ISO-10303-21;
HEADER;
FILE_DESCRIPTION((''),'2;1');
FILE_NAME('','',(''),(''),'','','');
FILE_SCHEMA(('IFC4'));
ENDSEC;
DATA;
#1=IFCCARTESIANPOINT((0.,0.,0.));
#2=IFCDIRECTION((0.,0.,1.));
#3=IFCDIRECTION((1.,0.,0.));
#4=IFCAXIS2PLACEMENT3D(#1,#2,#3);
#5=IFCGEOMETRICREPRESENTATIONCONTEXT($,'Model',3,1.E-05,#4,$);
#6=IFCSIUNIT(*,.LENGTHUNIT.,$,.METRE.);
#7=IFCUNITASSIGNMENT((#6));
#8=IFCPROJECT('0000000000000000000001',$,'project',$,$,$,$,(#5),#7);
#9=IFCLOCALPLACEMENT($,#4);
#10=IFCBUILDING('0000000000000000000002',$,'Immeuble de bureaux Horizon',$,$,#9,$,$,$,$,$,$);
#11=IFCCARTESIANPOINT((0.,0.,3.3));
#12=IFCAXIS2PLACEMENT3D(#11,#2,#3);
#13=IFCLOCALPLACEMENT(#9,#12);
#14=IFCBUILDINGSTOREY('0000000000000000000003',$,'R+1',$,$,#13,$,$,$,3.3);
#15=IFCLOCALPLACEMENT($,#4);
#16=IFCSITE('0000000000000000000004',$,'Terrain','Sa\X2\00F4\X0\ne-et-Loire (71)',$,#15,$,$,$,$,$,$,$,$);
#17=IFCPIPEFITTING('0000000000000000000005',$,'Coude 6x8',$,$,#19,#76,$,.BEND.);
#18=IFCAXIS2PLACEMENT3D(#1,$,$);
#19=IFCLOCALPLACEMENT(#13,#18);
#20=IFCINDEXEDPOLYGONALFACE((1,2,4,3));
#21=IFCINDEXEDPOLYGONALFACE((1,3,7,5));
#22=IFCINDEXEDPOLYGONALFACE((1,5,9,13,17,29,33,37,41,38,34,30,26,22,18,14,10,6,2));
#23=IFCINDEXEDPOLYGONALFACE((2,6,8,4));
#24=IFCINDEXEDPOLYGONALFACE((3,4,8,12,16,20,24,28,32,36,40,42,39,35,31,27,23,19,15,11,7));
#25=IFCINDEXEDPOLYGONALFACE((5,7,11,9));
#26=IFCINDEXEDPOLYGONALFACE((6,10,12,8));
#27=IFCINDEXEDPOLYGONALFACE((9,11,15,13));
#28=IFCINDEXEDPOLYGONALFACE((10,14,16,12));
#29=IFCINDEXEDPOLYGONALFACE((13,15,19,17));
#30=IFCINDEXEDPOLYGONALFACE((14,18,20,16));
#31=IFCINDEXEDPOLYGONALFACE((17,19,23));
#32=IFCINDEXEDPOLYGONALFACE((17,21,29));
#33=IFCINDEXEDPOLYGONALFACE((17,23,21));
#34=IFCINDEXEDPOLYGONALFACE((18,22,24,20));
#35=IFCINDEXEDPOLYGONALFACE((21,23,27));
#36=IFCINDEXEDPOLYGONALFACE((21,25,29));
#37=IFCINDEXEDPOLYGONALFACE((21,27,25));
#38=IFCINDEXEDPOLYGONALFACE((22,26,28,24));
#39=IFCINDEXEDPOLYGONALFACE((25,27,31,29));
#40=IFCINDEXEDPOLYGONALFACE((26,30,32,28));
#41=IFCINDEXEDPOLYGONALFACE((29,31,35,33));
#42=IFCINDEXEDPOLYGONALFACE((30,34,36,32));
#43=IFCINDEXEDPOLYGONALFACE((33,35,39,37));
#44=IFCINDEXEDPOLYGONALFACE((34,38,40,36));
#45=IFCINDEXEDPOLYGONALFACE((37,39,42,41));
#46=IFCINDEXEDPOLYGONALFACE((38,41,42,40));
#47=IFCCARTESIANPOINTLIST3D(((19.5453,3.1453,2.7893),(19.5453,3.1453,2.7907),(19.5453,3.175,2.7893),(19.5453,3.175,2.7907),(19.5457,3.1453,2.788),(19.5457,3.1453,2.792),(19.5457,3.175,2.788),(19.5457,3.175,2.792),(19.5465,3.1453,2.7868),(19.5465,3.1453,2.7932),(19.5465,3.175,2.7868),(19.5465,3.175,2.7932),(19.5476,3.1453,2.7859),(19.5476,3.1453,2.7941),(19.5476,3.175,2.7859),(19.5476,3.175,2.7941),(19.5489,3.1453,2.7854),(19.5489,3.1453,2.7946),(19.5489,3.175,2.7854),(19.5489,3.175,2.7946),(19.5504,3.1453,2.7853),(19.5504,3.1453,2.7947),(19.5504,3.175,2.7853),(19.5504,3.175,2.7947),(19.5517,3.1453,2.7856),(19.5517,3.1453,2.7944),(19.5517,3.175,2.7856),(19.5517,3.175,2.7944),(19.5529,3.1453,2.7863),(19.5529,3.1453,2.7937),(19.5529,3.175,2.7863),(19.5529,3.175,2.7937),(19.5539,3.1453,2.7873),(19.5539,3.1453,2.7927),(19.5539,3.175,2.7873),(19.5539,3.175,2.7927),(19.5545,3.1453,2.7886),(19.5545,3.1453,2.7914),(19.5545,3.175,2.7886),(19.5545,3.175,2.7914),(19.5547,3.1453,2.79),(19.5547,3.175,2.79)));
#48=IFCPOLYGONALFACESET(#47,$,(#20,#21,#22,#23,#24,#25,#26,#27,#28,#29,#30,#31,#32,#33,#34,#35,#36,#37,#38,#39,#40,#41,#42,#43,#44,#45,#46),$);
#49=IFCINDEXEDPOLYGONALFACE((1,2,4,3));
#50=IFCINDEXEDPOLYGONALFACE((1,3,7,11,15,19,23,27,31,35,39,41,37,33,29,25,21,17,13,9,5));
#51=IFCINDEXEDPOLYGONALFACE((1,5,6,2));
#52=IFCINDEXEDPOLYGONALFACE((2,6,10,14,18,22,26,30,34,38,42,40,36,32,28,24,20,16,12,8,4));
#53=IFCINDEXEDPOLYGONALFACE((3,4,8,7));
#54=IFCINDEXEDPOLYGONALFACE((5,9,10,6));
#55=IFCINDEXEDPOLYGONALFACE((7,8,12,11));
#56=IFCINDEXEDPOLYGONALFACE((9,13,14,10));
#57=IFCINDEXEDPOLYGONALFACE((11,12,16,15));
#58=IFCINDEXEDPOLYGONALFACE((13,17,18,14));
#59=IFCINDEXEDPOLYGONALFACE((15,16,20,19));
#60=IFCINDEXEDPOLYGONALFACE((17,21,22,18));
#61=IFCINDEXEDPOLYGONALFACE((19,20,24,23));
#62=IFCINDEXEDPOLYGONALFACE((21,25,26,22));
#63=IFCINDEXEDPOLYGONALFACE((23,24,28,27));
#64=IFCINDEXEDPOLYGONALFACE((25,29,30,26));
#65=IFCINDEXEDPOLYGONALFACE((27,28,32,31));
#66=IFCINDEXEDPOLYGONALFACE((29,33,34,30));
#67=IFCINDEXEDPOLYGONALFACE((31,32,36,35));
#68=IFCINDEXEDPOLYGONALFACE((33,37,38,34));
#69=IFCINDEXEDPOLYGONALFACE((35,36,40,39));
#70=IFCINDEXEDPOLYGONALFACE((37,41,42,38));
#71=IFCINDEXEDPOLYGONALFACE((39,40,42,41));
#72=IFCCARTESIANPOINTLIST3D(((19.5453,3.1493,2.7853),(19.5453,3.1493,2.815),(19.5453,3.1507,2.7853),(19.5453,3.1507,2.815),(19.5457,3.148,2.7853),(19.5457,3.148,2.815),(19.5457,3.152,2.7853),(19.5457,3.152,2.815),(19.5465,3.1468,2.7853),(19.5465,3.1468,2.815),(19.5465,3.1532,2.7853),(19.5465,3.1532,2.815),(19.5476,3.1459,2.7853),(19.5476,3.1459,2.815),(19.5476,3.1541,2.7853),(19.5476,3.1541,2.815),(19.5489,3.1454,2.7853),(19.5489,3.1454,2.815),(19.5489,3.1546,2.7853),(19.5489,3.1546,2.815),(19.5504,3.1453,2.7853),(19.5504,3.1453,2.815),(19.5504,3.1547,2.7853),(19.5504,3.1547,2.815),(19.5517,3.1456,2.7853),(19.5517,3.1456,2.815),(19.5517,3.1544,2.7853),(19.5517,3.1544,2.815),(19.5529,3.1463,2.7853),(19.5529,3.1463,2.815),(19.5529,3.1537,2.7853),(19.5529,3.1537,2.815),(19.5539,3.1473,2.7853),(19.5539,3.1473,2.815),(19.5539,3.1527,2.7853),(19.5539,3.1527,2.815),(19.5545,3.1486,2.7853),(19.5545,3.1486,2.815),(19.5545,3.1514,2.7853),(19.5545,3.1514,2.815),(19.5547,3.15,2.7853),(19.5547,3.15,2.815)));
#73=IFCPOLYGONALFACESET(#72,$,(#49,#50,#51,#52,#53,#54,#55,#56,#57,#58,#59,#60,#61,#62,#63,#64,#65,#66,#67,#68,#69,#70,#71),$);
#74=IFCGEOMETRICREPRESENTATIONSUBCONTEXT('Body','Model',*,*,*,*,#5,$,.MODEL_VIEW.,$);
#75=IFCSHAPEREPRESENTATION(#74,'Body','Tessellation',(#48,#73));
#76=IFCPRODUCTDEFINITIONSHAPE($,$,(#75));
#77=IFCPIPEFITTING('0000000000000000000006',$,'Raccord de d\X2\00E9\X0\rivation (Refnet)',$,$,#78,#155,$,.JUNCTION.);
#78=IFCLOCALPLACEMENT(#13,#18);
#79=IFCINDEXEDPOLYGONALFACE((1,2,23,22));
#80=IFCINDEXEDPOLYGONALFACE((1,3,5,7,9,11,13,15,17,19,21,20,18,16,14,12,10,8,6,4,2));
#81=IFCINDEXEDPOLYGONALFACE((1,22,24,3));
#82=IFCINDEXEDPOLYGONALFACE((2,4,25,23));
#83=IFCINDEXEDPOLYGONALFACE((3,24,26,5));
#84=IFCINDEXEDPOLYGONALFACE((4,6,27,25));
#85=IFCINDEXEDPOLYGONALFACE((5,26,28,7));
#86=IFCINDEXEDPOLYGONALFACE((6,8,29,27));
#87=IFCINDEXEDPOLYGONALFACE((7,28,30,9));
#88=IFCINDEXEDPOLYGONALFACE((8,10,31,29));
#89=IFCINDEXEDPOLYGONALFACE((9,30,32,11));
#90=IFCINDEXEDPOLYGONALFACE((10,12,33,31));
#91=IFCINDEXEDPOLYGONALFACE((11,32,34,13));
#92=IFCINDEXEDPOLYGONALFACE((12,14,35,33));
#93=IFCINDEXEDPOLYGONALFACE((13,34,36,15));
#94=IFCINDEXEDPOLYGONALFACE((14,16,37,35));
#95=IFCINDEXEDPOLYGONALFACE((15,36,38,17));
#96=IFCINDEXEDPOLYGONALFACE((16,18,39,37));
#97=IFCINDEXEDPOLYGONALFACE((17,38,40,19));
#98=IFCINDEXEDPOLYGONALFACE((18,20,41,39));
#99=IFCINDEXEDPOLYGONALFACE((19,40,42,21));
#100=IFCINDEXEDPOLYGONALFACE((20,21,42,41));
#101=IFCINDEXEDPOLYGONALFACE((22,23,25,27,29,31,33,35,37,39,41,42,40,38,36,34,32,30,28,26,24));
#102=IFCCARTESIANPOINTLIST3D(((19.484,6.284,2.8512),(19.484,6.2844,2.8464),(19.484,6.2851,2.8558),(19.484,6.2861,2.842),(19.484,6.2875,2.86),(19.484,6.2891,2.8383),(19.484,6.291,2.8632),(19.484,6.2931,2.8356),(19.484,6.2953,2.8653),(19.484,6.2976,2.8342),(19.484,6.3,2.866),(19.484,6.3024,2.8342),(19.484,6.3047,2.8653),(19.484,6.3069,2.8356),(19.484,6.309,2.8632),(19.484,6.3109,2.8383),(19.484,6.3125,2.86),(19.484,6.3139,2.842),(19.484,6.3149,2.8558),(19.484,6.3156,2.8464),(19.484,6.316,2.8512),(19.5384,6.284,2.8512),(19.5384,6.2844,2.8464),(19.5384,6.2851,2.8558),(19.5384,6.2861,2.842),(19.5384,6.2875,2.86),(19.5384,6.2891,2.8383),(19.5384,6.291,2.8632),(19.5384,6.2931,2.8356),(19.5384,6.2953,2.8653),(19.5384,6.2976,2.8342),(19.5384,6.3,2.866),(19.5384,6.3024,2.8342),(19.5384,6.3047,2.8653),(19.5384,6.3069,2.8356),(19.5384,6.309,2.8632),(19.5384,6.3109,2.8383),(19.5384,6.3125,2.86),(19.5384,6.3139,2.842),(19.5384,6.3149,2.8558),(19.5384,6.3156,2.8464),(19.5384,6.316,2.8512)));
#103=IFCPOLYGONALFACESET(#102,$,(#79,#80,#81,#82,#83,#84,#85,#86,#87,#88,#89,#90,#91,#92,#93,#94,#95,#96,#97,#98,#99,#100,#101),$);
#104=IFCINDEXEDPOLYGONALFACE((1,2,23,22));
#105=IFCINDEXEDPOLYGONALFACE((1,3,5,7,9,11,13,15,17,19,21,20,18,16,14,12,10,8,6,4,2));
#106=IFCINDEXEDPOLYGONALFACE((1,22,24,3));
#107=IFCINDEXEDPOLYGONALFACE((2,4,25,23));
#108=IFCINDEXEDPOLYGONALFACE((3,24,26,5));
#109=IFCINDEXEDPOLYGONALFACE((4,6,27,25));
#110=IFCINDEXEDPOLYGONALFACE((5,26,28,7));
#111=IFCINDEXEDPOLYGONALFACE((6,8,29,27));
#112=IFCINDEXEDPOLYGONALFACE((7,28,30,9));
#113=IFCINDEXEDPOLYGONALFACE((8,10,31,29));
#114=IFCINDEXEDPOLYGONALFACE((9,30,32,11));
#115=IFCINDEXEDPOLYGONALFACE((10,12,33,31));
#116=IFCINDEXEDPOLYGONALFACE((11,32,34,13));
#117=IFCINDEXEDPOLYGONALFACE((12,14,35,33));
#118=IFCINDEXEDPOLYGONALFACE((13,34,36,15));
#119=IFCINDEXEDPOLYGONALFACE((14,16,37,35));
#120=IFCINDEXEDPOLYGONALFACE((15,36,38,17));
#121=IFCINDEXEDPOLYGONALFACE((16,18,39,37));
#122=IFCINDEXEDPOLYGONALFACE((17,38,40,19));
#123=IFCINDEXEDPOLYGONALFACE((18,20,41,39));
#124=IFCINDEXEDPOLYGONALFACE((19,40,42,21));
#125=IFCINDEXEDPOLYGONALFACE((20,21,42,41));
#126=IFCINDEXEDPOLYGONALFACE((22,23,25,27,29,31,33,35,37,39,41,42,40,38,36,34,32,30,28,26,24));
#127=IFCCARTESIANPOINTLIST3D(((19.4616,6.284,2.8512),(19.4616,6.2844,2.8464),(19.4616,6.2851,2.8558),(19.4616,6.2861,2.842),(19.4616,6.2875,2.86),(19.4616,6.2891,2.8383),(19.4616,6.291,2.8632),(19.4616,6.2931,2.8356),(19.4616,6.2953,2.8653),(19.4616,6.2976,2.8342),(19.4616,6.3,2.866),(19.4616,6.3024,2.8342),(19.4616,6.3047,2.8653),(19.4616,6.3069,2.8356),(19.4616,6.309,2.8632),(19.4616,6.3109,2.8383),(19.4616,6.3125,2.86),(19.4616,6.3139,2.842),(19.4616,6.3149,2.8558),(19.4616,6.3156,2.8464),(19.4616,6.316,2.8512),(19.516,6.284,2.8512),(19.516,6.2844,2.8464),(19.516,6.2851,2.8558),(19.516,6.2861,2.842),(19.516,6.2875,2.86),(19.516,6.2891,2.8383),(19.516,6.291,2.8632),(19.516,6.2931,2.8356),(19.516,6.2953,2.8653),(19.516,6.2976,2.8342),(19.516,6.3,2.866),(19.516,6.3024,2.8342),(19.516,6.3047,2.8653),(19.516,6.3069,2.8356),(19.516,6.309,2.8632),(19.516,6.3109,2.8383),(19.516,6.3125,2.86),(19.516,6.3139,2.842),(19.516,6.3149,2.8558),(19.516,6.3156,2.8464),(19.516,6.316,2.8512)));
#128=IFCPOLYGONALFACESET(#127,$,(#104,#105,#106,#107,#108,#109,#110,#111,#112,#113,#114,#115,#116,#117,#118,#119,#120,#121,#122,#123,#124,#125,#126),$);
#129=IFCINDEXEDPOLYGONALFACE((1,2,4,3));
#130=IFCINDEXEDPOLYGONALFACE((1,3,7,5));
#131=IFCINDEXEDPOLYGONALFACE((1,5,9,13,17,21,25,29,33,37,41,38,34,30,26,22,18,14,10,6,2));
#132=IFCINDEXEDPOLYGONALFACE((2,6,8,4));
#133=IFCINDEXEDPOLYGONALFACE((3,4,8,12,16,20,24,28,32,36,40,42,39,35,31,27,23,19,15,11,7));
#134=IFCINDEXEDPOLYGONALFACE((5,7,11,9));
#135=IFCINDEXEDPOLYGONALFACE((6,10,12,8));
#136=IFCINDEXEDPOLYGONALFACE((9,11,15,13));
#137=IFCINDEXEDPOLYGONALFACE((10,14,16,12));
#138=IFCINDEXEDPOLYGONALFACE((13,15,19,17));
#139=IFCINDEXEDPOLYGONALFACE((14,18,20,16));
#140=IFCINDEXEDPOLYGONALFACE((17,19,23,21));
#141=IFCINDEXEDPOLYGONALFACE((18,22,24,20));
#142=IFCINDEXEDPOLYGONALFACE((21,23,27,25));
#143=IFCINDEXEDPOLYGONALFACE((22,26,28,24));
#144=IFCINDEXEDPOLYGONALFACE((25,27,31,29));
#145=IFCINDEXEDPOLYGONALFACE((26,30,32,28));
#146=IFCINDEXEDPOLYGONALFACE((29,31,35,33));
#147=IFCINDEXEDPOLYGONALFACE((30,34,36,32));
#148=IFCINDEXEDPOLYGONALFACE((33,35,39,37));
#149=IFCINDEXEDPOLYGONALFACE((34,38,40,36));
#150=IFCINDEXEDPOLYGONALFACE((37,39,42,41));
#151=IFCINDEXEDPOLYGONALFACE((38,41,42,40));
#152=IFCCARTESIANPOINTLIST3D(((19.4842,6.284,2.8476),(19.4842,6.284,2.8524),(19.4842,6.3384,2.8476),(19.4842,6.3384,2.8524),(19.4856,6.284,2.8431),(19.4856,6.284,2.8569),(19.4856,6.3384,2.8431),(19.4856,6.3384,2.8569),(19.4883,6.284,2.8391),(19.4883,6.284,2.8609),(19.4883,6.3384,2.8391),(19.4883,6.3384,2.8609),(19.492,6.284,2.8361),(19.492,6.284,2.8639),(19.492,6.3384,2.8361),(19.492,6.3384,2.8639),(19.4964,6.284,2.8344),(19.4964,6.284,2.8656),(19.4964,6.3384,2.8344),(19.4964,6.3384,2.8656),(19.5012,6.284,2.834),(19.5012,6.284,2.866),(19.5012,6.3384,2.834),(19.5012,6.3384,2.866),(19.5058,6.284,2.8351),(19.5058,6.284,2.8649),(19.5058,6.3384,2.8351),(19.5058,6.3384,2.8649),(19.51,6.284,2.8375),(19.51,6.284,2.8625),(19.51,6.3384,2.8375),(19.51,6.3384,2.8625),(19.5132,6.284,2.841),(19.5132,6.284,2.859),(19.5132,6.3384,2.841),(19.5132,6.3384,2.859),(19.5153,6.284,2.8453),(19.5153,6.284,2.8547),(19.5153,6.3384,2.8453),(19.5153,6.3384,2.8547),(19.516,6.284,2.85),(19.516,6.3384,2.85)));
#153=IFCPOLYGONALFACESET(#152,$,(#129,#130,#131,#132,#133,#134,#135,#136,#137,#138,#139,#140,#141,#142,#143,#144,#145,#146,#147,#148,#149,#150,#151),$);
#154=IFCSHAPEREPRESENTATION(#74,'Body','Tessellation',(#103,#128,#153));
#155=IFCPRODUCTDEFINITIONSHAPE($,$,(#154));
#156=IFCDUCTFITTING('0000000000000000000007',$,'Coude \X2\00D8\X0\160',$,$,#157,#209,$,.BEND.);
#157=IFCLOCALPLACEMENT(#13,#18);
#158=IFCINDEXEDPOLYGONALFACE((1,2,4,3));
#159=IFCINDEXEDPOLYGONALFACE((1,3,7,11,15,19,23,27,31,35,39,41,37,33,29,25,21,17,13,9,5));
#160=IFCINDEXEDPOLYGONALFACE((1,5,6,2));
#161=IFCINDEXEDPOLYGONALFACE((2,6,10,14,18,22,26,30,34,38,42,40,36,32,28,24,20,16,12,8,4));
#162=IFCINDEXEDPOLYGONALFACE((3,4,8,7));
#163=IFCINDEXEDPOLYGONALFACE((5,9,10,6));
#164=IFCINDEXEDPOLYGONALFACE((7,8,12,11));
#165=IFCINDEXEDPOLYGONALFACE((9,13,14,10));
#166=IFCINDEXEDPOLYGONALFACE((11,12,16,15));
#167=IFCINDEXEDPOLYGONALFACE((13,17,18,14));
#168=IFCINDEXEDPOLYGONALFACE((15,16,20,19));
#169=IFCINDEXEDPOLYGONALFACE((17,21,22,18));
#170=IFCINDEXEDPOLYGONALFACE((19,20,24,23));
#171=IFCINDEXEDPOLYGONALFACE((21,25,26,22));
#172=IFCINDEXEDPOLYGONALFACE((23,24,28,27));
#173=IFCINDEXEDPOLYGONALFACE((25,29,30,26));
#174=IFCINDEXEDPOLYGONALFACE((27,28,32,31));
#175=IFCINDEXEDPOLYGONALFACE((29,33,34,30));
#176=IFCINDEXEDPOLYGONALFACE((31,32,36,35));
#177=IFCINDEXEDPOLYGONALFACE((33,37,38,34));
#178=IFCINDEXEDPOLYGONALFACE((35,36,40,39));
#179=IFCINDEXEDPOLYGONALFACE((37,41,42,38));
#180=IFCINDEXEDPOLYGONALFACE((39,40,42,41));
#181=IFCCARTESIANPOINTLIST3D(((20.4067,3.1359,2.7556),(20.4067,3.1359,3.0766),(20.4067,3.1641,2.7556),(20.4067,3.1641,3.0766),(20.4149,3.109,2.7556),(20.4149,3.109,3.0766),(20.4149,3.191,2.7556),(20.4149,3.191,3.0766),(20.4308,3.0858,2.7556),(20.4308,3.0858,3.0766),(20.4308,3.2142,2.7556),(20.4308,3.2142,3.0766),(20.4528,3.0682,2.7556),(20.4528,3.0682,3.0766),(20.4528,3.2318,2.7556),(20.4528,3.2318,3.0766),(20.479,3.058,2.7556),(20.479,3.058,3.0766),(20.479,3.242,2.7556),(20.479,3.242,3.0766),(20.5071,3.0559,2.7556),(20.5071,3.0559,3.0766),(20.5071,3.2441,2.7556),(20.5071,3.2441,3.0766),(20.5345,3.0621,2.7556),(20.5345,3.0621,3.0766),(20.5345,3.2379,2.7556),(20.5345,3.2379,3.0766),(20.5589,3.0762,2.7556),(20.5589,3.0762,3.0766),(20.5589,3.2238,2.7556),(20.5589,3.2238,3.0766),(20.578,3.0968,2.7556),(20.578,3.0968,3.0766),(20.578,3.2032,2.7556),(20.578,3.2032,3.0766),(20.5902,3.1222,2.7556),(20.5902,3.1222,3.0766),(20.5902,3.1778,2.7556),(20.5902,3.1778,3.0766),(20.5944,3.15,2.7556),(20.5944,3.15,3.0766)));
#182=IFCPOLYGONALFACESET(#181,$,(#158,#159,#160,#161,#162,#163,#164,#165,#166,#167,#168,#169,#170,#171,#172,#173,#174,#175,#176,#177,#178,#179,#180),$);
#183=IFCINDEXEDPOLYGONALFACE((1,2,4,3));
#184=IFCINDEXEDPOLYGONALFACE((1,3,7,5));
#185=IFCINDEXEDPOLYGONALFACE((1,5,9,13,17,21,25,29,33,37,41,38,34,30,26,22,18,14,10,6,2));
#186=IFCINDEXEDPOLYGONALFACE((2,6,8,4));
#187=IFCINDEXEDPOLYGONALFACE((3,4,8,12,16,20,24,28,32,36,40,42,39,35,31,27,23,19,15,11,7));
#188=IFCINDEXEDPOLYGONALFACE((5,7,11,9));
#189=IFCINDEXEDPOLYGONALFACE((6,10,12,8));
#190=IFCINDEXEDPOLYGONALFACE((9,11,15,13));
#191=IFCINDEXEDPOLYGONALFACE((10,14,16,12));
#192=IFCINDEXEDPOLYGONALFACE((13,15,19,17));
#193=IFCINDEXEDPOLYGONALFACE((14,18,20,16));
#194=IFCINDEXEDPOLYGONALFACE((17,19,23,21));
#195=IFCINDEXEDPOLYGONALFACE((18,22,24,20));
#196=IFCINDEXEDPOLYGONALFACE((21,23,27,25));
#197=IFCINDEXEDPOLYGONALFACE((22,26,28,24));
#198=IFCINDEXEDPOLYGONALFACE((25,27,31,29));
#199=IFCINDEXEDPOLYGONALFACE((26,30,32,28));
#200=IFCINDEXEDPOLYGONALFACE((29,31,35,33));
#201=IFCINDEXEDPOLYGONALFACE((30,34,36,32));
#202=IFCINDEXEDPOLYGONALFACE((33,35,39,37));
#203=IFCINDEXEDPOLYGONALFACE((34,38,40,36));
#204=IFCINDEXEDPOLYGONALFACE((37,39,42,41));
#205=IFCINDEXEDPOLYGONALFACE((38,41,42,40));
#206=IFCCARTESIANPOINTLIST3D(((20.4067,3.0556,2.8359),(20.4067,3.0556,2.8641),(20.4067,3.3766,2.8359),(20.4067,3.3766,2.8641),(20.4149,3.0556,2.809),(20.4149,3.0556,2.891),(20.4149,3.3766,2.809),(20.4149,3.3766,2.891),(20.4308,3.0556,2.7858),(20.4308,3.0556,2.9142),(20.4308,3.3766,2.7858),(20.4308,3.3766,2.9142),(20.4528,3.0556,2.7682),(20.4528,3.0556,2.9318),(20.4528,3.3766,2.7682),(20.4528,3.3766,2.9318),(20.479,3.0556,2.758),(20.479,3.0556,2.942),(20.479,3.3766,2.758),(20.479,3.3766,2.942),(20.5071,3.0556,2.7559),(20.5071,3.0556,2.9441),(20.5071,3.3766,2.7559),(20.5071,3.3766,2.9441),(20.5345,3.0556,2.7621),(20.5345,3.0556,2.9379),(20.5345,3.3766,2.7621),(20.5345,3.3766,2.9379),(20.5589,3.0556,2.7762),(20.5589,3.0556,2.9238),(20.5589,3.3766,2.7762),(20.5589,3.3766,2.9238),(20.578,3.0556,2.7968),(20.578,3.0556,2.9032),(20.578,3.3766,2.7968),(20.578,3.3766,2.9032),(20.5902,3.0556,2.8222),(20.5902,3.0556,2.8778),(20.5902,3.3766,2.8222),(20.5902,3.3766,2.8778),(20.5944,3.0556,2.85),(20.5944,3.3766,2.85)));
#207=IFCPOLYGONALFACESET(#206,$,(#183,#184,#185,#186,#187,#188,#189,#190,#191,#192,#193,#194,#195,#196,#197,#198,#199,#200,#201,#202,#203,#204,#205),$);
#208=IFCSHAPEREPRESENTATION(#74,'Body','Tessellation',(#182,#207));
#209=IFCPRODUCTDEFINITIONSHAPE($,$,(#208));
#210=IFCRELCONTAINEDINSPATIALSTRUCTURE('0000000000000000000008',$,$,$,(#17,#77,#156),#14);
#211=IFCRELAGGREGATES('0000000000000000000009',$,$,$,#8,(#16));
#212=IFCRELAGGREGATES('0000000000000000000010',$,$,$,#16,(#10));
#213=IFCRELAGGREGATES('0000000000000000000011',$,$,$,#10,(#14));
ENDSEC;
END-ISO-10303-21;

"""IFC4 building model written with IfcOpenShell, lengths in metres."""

from ifc_helpers import new_model, si_unit, frame, origin_with_axes, place, context, subcontext, project, spatial, circle, extrude, element, save


model = new_model("IFC4")

# Units and contexts
model_context = context("Model", 3, precision=1e-05, world=origin_with_axes())
body_context = subcontext(model_context, "Body", "Model", "MODEL_VIEW")
ifc_project = project(units=[si_unit("LENGTHUNIT", "METRE")], contexts=[model_context])

# Site, building, storey
site_placement = place(None, origin_with_axes())
site = spatial("IfcSite", under=ifc_project, at=site_placement, Name="Terrain", Description="Saône-et-Loire (71)")
building_placement = place(None, origin_with_axes())
building = spatial("IfcBuilding", under=site, at=building_placement, Name="Immeuble de bureaux Horizon")
storey_placement = place(building_placement, frame((0.0, 0.0, 3.3), z_axis=(0.0, 0.0, 1.0), x_axis=(1.0, 0.0, 0.0)))
storey = spatial("IfcBuildingStorey", under=building, at=storey_placement, Name="R+1", Elevation=3.3)

# Pipe fittings
pipe_fitting_1_placement = place(storey_placement, frame((19.55, 3.15, 2.79), z_axis=(0.0, 0.0, 1.0), x_axis=(1.0, 0.0, 0.0)))
element("IfcPipeFitting", 1, at=pipe_fitting_1_placement, inside=storey, Name="Coude 6x8", PredefinedType="BEND", context=body_context, shape_type="SweptSolid", body=[
    extrude(circle(Radius=0.0047), frame((0.0, -0.0047, 0.0), z_axis=(0.0, 1.0, 0.0), x_axis=(1.0, 0.0, 0.0)), (0.0, 0.0, 1.0), 0.0297),
    extrude(circle(Radius=0.0047), frame((0.0, 0.0, -0.0047), z_axis=(0.0, 0.0, 1.0), x_axis=(1.0, 0.0, 0.0)), (0.0, 0.0, 1.0), 0.0297),
])
pipe_fitting_2_placement = place(storey_placement, frame((19.5, 6.3, 2.85), z_axis=(0.0, 0.0, 1.0), x_axis=(1.0, 0.0, 0.0)))
element("IfcPipeFitting", 2, at=pipe_fitting_2_placement, inside=storey, Name="Raccord de dérivation (Refnet)", PredefinedType="JUNCTION", context=body_context, shape_type="SweptSolid", body=[
    extrude(circle(Radius=0.016), frame((-0.016, 0.0, 0.0), z_axis=(1.0, 0.0, 0.0), x_axis=(0.0, 0.0, 1.0)), (0.0, 0.0, 1.0), 0.0544),
    extrude(circle(Radius=0.016), frame((0.016, 0.0, 0.0), z_axis=(-1.0, 0.0, 0.0), x_axis=(0.0, 0.0, 1.0)), (0.0, 0.0, 1.0), 0.0544),
    extrude(circle(Radius=0.016), frame((0.0, -0.016, 0.0), z_axis=(0.0, 1.0, 0.0), x_axis=(1.0, 0.0, 0.0)), (0.0, 0.0, 1.0), 0.0544),
])

# Duct fitting
duct_fitting_1_placement = place(storey_placement, frame((20.5, 3.15, 2.85), z_axis=(0.0, 0.0, 1.0), x_axis=(1.0, 0.0, 0.0)))
element("IfcDuctFitting", 3, at=duct_fitting_1_placement, inside=storey, Name="Coude Ø160", PredefinedType="BEND", context=body_context, shape_type="SweptSolid", body=[
    extrude(circle(Radius=0.0944), frame((0.0, 0.0, -0.0944), z_axis=(0.0, 0.0, 1.0), x_axis=(1.0, 0.0, 0.0)), (0.0, 0.0, 1.0), 0.321),
    extrude(circle(Radius=0.0944), frame((0.0, -0.0944, 0.0), z_axis=(0.0, 1.0, 0.0), x_axis=(1.0, 0.0, 0.0)), (0.0, 0.0, 1.0), 0.321),
])

save(model, "model.ifc")
